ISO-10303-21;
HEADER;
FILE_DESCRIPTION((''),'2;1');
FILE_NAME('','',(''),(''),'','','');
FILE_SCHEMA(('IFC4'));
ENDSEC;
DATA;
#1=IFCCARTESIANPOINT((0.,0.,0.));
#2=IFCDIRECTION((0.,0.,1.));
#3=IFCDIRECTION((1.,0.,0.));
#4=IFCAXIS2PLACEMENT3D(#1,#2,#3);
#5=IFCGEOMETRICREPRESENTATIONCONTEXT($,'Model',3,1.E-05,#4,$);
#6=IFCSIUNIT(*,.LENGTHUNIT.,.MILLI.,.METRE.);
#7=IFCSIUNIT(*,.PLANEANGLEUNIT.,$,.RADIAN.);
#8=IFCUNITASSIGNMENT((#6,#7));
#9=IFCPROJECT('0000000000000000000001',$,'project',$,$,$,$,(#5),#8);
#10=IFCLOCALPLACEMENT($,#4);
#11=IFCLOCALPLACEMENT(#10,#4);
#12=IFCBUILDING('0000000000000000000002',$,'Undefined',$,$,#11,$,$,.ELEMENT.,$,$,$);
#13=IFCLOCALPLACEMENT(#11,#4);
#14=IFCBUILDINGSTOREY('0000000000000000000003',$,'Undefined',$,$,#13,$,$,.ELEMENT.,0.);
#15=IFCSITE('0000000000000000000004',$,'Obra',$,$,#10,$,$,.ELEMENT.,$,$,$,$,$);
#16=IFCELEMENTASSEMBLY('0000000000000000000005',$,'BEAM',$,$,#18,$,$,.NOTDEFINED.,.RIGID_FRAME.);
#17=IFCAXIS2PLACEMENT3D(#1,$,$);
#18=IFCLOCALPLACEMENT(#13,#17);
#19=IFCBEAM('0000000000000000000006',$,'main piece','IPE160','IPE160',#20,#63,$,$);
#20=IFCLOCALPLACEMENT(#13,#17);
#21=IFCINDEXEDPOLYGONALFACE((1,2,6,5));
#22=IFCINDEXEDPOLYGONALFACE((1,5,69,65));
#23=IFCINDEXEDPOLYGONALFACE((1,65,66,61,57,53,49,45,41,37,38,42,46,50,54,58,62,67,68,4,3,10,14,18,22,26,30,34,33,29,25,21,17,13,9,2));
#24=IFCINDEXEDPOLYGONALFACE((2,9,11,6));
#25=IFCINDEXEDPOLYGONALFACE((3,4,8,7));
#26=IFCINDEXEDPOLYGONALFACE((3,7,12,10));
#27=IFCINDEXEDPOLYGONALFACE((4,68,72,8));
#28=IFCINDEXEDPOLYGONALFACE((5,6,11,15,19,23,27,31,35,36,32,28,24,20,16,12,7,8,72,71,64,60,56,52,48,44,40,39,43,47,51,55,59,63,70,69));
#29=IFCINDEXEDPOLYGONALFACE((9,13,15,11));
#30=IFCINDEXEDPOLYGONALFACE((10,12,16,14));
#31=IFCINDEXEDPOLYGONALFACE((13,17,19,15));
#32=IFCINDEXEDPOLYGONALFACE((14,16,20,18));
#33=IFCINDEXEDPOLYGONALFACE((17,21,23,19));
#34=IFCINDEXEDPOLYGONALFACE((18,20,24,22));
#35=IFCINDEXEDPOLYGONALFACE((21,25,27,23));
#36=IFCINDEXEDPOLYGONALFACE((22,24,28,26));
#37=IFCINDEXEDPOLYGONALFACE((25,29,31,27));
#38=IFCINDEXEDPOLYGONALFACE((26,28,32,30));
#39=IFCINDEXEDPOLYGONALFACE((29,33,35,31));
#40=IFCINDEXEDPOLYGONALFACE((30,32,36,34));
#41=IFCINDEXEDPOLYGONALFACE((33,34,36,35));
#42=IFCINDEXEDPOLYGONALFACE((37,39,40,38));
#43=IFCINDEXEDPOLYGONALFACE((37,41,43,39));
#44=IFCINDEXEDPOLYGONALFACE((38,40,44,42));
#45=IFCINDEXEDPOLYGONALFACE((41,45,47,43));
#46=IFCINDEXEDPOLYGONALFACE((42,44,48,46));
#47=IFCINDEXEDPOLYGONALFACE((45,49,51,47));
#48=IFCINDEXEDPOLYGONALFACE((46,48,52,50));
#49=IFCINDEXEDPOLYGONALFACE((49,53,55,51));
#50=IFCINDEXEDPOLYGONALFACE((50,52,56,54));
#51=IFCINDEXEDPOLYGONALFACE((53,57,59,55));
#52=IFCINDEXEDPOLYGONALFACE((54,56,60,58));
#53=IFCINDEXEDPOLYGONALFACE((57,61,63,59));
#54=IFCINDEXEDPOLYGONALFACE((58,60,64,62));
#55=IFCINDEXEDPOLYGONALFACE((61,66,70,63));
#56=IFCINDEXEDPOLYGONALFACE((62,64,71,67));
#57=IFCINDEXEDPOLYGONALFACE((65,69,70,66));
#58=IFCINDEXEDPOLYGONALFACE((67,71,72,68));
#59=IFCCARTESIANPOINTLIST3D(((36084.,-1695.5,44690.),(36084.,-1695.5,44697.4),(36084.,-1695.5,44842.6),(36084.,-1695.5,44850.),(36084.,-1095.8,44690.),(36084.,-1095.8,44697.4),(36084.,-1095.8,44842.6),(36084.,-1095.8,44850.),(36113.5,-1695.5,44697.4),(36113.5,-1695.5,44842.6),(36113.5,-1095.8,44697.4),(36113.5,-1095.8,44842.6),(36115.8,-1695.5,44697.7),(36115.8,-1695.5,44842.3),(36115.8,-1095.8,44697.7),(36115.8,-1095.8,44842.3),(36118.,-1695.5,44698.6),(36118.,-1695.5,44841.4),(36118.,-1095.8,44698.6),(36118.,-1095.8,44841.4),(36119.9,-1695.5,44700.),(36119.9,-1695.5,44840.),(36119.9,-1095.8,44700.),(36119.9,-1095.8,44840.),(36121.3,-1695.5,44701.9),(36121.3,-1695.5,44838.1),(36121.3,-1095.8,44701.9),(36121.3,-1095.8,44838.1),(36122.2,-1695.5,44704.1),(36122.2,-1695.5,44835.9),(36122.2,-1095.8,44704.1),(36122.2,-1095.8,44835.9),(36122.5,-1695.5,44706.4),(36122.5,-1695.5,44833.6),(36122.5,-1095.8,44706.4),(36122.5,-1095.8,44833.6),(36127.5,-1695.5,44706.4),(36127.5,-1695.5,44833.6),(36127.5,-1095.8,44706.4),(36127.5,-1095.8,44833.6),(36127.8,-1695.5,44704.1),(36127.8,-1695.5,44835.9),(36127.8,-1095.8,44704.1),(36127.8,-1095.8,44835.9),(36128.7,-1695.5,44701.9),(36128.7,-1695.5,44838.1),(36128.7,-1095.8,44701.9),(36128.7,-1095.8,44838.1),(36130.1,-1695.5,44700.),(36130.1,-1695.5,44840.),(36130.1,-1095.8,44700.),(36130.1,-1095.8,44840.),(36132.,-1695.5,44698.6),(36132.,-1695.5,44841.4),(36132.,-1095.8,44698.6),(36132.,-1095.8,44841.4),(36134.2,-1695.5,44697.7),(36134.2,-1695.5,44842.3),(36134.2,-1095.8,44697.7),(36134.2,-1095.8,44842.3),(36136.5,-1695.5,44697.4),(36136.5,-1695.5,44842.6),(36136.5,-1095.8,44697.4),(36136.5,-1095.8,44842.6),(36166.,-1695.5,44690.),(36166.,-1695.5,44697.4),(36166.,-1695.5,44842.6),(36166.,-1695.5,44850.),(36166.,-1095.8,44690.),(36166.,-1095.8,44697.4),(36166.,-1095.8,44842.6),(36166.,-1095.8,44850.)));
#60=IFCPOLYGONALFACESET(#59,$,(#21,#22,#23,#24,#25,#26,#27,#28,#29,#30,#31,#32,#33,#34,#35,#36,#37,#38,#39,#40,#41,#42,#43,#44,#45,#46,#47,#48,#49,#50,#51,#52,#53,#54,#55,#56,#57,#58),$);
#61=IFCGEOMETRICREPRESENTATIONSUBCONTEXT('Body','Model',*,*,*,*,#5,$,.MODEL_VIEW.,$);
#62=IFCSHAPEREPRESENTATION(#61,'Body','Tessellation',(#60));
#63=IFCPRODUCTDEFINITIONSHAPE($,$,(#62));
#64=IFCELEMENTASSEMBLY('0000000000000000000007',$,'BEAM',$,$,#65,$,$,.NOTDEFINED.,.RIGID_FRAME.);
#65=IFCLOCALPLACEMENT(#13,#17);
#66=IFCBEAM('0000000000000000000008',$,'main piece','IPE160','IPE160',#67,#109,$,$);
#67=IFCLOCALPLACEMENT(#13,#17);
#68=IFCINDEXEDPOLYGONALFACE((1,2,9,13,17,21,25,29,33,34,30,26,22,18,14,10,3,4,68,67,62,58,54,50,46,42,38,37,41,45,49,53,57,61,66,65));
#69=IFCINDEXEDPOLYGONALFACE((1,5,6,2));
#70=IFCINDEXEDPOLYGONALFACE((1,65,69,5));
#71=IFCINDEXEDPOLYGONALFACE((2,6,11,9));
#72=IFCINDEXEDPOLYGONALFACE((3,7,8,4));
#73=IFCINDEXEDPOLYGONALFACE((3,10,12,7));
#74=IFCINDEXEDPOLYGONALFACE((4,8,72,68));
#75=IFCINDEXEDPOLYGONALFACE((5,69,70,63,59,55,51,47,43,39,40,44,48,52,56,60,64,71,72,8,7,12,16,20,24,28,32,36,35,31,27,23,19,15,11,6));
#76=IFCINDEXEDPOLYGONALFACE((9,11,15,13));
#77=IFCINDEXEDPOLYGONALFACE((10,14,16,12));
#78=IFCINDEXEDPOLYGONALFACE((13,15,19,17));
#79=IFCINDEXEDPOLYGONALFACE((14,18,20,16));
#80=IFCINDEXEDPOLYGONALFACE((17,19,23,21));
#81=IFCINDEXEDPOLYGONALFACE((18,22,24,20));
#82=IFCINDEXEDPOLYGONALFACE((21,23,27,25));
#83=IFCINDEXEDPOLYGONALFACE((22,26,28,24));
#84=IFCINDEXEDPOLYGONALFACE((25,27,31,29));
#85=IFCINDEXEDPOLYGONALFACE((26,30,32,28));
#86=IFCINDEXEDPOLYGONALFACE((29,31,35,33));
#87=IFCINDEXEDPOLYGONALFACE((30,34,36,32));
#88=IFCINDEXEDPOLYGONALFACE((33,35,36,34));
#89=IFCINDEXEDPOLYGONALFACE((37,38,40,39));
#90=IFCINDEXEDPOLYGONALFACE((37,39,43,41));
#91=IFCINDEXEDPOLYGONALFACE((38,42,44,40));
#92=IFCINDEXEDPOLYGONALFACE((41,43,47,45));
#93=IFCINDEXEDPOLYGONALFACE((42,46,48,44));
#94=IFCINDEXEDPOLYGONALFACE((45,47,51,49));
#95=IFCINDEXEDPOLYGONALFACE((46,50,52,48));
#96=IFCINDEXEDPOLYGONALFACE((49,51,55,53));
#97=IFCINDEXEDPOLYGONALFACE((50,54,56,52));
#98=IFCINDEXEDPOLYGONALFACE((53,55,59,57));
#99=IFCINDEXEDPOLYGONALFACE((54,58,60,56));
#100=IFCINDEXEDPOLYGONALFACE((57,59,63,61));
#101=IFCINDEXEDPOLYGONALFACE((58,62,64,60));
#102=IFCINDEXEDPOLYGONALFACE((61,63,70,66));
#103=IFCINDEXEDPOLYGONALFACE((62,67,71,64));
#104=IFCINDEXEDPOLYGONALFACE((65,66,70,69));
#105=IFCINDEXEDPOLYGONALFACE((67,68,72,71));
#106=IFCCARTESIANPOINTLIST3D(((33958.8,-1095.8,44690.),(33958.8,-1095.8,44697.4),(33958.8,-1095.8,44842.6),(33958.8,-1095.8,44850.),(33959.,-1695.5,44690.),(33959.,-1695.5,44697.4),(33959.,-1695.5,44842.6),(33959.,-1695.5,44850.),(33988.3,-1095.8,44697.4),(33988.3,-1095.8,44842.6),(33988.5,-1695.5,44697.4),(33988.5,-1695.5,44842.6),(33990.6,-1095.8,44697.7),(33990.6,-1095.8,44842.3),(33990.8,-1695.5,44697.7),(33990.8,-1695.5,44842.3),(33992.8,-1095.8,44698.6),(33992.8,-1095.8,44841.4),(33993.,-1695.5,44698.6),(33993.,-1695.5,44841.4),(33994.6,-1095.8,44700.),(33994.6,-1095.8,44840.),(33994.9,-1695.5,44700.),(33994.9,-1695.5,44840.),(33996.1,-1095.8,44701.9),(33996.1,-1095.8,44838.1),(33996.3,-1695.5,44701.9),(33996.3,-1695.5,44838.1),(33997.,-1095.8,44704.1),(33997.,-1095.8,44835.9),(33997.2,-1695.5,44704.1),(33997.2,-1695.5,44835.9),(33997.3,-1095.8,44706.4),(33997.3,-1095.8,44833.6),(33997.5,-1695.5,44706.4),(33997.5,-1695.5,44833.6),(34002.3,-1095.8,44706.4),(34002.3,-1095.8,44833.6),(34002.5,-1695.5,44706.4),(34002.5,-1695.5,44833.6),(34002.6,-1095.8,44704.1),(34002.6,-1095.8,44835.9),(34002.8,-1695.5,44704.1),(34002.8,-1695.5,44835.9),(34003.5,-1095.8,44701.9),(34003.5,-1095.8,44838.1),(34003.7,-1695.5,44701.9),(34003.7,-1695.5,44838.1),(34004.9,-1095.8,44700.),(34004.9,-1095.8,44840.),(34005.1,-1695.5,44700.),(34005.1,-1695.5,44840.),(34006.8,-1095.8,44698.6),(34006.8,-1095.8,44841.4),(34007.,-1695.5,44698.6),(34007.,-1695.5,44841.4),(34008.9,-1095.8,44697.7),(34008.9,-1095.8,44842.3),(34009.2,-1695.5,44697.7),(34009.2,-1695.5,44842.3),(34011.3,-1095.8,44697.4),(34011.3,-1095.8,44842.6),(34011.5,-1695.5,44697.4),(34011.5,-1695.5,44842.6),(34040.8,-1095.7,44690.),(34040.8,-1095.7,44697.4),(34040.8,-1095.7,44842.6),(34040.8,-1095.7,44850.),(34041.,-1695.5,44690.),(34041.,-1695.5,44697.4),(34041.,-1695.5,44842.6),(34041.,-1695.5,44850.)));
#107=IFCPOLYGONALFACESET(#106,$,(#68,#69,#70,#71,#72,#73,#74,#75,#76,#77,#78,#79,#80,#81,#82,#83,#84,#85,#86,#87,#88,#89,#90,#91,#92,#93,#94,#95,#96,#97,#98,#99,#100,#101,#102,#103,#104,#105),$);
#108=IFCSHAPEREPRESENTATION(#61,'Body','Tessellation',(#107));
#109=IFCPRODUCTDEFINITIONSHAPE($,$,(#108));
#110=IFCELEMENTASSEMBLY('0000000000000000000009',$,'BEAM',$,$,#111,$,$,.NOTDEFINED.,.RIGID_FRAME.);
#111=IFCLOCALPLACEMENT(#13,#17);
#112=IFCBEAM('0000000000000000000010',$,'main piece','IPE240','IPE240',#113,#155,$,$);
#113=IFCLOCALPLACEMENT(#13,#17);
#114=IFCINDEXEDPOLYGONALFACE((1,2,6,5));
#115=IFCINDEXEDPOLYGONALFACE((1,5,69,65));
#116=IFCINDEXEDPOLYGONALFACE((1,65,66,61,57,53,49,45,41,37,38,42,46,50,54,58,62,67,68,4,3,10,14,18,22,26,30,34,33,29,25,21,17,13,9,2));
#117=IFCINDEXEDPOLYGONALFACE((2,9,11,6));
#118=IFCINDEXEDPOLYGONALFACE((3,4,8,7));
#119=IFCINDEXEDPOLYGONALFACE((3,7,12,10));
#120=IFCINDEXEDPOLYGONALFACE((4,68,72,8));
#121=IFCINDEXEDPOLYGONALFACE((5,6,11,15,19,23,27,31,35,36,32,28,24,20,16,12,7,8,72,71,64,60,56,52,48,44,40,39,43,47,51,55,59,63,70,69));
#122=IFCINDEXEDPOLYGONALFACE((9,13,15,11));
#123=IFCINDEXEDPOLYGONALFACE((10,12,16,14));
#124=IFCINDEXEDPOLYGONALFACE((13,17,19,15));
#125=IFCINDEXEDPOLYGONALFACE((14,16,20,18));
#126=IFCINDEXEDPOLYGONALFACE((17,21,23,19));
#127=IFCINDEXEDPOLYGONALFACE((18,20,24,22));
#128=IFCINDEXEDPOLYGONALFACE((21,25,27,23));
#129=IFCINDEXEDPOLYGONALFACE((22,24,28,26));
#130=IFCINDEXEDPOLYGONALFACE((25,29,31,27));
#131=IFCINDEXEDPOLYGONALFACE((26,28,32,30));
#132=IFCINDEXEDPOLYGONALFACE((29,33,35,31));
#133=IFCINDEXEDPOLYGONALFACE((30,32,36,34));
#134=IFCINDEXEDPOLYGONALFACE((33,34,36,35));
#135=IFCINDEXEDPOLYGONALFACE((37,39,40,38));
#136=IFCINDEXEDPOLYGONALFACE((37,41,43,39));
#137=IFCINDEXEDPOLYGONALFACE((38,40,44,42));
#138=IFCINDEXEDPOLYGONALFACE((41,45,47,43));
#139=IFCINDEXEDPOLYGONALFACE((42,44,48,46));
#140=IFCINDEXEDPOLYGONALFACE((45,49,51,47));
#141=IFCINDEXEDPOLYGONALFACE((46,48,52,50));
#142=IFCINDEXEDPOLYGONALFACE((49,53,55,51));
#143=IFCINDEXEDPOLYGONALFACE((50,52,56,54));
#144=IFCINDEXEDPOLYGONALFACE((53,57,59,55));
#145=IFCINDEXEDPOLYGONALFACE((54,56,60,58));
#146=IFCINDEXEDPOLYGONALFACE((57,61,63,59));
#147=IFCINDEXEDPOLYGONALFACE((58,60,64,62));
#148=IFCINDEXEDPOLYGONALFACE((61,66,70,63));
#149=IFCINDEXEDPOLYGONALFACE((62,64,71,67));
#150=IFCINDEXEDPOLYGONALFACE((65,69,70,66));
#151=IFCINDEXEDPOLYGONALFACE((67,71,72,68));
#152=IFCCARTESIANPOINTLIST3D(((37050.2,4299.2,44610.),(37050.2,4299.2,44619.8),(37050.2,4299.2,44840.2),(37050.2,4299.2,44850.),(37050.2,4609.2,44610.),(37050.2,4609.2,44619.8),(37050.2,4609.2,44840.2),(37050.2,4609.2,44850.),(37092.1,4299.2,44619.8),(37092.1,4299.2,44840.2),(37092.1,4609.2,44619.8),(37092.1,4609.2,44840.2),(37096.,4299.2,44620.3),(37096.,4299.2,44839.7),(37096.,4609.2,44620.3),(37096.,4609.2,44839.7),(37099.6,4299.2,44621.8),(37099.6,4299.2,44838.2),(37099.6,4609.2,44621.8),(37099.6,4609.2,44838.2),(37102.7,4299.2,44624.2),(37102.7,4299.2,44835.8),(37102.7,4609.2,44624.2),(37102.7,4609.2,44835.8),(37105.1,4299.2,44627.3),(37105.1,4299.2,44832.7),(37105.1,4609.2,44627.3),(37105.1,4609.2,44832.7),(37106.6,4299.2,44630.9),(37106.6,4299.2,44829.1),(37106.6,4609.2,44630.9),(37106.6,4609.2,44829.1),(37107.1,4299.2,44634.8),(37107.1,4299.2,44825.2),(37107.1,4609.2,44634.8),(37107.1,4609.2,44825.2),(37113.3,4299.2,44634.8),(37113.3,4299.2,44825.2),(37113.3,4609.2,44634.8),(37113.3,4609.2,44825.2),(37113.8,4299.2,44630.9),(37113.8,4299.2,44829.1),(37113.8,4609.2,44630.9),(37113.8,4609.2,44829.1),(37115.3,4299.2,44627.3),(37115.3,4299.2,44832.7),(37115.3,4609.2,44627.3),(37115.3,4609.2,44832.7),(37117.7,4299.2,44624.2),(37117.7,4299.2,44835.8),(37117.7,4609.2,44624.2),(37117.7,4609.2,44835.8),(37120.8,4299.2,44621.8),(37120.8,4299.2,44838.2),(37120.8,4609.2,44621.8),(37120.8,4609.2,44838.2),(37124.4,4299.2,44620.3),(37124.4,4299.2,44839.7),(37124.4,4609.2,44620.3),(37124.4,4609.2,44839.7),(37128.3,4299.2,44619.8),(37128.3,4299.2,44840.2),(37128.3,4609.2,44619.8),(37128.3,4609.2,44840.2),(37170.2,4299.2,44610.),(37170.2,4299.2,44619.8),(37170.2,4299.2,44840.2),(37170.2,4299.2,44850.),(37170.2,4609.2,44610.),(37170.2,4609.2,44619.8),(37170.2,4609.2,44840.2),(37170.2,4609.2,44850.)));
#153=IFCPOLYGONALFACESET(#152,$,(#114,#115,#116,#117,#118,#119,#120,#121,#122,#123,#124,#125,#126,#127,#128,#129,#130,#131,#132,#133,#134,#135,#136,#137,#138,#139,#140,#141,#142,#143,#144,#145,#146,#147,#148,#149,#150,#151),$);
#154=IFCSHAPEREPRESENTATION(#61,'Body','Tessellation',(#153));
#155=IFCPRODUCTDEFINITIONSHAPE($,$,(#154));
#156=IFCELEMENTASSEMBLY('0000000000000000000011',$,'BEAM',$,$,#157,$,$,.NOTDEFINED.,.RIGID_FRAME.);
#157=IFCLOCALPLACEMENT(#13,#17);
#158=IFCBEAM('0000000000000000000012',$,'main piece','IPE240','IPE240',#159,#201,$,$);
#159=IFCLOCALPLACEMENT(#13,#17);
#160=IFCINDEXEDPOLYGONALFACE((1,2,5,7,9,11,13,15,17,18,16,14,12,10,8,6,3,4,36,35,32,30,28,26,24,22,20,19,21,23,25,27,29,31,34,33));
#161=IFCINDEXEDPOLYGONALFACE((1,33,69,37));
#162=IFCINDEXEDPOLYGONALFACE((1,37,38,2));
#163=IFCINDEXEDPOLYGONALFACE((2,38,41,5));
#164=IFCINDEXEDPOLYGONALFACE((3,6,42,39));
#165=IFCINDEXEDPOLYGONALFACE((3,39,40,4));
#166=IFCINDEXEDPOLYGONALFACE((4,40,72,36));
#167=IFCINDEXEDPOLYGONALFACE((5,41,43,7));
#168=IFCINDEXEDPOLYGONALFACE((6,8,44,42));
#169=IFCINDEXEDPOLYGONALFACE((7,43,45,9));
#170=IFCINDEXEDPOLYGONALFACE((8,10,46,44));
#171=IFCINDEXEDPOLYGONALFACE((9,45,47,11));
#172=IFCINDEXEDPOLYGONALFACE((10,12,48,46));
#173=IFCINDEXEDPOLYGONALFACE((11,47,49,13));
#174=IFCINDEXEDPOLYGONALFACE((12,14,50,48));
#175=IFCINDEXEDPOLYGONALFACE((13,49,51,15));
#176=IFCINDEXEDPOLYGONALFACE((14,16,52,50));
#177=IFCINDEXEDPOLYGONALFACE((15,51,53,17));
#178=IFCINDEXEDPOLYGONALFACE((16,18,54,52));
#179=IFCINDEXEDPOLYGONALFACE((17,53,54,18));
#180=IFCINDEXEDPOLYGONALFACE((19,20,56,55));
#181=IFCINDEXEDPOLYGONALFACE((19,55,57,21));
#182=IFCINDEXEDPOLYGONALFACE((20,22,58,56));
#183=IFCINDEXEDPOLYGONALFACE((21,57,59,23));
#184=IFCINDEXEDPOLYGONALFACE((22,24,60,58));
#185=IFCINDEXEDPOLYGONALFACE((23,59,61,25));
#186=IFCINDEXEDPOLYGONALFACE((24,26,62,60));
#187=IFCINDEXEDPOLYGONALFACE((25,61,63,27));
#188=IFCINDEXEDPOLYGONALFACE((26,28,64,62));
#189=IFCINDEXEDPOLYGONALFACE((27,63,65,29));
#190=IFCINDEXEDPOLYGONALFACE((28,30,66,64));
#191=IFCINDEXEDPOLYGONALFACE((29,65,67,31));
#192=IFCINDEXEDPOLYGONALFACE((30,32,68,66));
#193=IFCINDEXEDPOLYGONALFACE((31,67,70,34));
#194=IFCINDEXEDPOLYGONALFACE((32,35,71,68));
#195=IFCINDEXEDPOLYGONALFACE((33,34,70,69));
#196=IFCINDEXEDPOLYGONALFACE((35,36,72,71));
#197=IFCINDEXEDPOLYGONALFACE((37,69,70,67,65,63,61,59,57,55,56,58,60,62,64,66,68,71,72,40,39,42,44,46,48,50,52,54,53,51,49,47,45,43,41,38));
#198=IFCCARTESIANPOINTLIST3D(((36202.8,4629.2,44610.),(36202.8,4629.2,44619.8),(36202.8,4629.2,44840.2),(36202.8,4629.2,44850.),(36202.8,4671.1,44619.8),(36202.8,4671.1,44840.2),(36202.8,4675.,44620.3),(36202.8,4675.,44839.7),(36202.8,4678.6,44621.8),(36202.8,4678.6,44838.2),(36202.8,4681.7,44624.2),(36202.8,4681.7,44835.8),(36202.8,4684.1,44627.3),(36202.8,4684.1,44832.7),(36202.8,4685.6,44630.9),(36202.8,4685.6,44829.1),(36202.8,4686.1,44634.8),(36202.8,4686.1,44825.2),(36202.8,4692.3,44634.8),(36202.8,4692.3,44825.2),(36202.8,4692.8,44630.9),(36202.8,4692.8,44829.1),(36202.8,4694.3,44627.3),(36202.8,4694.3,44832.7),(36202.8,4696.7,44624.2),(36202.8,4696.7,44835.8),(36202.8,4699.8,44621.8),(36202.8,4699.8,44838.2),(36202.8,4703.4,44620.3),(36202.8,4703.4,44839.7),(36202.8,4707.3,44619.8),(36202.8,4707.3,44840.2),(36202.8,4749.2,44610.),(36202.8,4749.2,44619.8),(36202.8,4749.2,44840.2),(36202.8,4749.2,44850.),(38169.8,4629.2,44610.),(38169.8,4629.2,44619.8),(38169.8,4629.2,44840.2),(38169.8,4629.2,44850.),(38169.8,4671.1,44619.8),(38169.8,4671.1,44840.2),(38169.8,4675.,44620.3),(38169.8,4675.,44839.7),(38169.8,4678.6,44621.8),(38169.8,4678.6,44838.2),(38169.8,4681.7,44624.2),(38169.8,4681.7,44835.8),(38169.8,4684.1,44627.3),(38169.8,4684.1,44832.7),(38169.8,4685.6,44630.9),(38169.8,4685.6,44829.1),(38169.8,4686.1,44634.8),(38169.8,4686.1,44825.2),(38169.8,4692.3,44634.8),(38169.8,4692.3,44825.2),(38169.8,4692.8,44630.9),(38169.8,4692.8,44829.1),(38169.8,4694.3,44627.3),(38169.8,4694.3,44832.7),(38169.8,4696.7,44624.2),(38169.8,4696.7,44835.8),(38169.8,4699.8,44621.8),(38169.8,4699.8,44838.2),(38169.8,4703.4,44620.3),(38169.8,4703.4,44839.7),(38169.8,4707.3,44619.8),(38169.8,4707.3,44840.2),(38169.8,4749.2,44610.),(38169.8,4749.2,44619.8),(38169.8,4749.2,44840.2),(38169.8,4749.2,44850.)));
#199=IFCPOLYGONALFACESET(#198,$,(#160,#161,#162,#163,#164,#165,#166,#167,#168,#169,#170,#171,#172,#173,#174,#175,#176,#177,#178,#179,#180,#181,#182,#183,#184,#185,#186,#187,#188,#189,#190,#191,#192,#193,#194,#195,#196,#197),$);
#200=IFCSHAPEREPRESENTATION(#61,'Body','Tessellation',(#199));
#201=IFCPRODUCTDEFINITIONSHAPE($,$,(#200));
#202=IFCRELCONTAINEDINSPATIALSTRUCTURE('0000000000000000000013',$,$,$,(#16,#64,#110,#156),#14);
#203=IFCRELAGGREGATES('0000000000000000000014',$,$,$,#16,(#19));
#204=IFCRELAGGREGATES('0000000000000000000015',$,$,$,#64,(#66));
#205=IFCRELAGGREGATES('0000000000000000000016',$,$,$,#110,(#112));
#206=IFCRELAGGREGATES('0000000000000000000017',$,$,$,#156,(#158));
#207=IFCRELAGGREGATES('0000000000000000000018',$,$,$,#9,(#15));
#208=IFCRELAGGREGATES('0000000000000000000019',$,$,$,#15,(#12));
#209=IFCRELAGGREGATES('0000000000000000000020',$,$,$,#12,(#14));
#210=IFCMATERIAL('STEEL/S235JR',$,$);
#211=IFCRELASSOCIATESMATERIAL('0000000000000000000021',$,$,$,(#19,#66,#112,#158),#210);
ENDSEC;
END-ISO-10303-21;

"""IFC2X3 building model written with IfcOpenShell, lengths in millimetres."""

from ifc_helpers import new_model, si_unit, frame, origin_with_axes, origin_2d_with_axis, place, context, subcontext, project, spatial, i_section, extrude, material, element, aggregate, save


model = new_model("IFC2X3")

# Units and contexts
model_context = context("Model", 3, precision=1e-05, world=origin_with_axes())
body_context = subcontext(model_context, "Body", "Model", "MODEL_VIEW")
ifc_project = project(units=[si_unit("LENGTHUNIT", "METRE", prefix="MILLI"), si_unit("PLANEANGLEUNIT", "RADIAN")], contexts=[model_context])

# Site, building, storey
site_placement = place(None, origin_with_axes())
site = spatial("IfcSite", under=ifc_project, at=site_placement, Name="Obra", CompositionType="ELEMENT")
building_placement = place(site_placement, origin_with_axes())
building = spatial("IfcBuilding", under=site, at=building_placement, Name="Undefined", CompositionType="ELEMENT")
storey_placement = place(building_placement, origin_with_axes())
storey = spatial("IfcBuildingStorey", under=building, at=storey_placement, Name="Undefined", CompositionType="ELEMENT", Elevation=0.0)

# Shared definitions
ifc_material_1 = material(Name="STEEL/S235JR")

# Element assemblies, beams
assembly_1_placement = place(storey_placement, origin_with_axes())
assembly_1 = element("IfcElementAssembly", 1, at=assembly_1_placement, inside=storey, Name="BEAM", AssemblyPlace="NOTDEFINED", PredefinedType="RIGID_FRAME")
beam_1_placement = place(assembly_1_placement, frame((36125.0, -1695.5, 44770.0), z_axis=(0.0, 0.0, 1.0), x_axis=(0.0, 1.0, 0.0)))
beam_1 = element("IfcBeam", 2, at=beam_1_placement, material=ifc_material_1, Name="main piece", Description="IPE160", ObjectType="IPE160", context=body_context, shape_type="SweptSolid", body=[
    extrude(i_section(OverallWidth=82.0, OverallDepth=160.0, WebThickness=5.0, FlangeThickness=7.4, FilletRadius=9.0, at=origin_2d_with_axis()), frame((599.7, 0.0, 0.0), z_axis=(-1.0, 0.0, 0.0), x_axis=(0.0, -1.0, 0.0)), (0.0, 0.0, 1.0), 599.7),
])
aggregate(assembly_1, [beam_1])
assembly_2_placement = place(storey_placement, origin_with_axes())
assembly_2 = element("IfcElementAssembly", 3, at=assembly_2_placement, inside=storey, Name="BEAM", AssemblyPlace="NOTDEFINED", PredefinedType="RIGID_FRAME")
beam_2_placement = place(assembly_2_placement, frame((33999.8, -1095.8, 44770.0), z_axis=(0.0, 0.0, 1.0), x_axis=(0.000388, -1.0, 0.0)))
beam_2 = element("IfcBeam", 4, at=beam_2_placement, material=ifc_material_1, Name="main piece", Description="IPE160", ObjectType="IPE160", context=body_context, shape_type="SweptSolid", body=[
    extrude(i_section(OverallWidth=82.0, OverallDepth=160.0, WebThickness=5.0, FlangeThickness=7.4, FilletRadius=9.0, at=origin_2d_with_axis()), frame((599.7, 0.0, 0.0), z_axis=(-1.0, 0.0, 0.0), x_axis=(0.0, -1.0, 0.0)), (0.0, 0.0, 1.0), 599.7),
])
aggregate(assembly_2, [beam_2])
assembly_3_placement = place(storey_placement, origin_with_axes())
assembly_3 = element("IfcElementAssembly", 5, at=assembly_3_placement, inside=storey, Name="BEAM", AssemblyPlace="NOTDEFINED", PredefinedType="RIGID_FRAME")
beam_3_placement = place(assembly_3_placement, frame((37110.2, 4299.2, 44730.0), z_axis=(0.0, 0.0, 1.0), x_axis=(0.0, 1.0, 0.0)))
beam_3 = element("IfcBeam", 6, at=beam_3_placement, material=ifc_material_1, Name="main piece", Description="IPE240", ObjectType="IPE240", context=body_context, shape_type="SweptSolid", body=[
    extrude(i_section(OverallWidth=120.0, OverallDepth=240.0, WebThickness=6.2, FlangeThickness=9.8, FilletRadius=15.0, at=origin_2d_with_axis()), frame((310.0, 0.0, 0.0), z_axis=(-1.0, 0.0, 0.0), x_axis=(0.0, -1.0, 0.0)), (0.0, 0.0, 1.0), 310.0),
])
aggregate(assembly_3, [beam_3])
assembly_4_placement = place(storey_placement, origin_with_axes())
assembly_4 = element("IfcElementAssembly", 7, at=assembly_4_placement, inside=storey, Name="BEAM", AssemblyPlace="NOTDEFINED", PredefinedType="RIGID_FRAME")
beam_4_placement = place(assembly_4_placement, frame((38169.8, 4689.2, 44730.0), z_axis=(0.0, 0.0, 1.0), x_axis=(-1.0, 0.0, 0.0)))
beam_4 = element("IfcBeam", 8, at=beam_4_placement, material=ifc_material_1, Name="main piece", Description="IPE240", ObjectType="IPE240", context=body_context, shape_type="SweptSolid", body=[
    extrude(i_section(OverallWidth=120.0, OverallDepth=240.0, WebThickness=6.2, FlangeThickness=9.8, FilletRadius=15.0, at=origin_2d_with_axis()), frame((1967.0, 0.0, 0.0), z_axis=(-1.0, 0.0, 0.0), x_axis=(0.0, -1.0, 0.0)), (0.0, 0.0, 1.0), 1967.0),
])
aggregate(assembly_4, [beam_4])

save(model, "model.ifc")
